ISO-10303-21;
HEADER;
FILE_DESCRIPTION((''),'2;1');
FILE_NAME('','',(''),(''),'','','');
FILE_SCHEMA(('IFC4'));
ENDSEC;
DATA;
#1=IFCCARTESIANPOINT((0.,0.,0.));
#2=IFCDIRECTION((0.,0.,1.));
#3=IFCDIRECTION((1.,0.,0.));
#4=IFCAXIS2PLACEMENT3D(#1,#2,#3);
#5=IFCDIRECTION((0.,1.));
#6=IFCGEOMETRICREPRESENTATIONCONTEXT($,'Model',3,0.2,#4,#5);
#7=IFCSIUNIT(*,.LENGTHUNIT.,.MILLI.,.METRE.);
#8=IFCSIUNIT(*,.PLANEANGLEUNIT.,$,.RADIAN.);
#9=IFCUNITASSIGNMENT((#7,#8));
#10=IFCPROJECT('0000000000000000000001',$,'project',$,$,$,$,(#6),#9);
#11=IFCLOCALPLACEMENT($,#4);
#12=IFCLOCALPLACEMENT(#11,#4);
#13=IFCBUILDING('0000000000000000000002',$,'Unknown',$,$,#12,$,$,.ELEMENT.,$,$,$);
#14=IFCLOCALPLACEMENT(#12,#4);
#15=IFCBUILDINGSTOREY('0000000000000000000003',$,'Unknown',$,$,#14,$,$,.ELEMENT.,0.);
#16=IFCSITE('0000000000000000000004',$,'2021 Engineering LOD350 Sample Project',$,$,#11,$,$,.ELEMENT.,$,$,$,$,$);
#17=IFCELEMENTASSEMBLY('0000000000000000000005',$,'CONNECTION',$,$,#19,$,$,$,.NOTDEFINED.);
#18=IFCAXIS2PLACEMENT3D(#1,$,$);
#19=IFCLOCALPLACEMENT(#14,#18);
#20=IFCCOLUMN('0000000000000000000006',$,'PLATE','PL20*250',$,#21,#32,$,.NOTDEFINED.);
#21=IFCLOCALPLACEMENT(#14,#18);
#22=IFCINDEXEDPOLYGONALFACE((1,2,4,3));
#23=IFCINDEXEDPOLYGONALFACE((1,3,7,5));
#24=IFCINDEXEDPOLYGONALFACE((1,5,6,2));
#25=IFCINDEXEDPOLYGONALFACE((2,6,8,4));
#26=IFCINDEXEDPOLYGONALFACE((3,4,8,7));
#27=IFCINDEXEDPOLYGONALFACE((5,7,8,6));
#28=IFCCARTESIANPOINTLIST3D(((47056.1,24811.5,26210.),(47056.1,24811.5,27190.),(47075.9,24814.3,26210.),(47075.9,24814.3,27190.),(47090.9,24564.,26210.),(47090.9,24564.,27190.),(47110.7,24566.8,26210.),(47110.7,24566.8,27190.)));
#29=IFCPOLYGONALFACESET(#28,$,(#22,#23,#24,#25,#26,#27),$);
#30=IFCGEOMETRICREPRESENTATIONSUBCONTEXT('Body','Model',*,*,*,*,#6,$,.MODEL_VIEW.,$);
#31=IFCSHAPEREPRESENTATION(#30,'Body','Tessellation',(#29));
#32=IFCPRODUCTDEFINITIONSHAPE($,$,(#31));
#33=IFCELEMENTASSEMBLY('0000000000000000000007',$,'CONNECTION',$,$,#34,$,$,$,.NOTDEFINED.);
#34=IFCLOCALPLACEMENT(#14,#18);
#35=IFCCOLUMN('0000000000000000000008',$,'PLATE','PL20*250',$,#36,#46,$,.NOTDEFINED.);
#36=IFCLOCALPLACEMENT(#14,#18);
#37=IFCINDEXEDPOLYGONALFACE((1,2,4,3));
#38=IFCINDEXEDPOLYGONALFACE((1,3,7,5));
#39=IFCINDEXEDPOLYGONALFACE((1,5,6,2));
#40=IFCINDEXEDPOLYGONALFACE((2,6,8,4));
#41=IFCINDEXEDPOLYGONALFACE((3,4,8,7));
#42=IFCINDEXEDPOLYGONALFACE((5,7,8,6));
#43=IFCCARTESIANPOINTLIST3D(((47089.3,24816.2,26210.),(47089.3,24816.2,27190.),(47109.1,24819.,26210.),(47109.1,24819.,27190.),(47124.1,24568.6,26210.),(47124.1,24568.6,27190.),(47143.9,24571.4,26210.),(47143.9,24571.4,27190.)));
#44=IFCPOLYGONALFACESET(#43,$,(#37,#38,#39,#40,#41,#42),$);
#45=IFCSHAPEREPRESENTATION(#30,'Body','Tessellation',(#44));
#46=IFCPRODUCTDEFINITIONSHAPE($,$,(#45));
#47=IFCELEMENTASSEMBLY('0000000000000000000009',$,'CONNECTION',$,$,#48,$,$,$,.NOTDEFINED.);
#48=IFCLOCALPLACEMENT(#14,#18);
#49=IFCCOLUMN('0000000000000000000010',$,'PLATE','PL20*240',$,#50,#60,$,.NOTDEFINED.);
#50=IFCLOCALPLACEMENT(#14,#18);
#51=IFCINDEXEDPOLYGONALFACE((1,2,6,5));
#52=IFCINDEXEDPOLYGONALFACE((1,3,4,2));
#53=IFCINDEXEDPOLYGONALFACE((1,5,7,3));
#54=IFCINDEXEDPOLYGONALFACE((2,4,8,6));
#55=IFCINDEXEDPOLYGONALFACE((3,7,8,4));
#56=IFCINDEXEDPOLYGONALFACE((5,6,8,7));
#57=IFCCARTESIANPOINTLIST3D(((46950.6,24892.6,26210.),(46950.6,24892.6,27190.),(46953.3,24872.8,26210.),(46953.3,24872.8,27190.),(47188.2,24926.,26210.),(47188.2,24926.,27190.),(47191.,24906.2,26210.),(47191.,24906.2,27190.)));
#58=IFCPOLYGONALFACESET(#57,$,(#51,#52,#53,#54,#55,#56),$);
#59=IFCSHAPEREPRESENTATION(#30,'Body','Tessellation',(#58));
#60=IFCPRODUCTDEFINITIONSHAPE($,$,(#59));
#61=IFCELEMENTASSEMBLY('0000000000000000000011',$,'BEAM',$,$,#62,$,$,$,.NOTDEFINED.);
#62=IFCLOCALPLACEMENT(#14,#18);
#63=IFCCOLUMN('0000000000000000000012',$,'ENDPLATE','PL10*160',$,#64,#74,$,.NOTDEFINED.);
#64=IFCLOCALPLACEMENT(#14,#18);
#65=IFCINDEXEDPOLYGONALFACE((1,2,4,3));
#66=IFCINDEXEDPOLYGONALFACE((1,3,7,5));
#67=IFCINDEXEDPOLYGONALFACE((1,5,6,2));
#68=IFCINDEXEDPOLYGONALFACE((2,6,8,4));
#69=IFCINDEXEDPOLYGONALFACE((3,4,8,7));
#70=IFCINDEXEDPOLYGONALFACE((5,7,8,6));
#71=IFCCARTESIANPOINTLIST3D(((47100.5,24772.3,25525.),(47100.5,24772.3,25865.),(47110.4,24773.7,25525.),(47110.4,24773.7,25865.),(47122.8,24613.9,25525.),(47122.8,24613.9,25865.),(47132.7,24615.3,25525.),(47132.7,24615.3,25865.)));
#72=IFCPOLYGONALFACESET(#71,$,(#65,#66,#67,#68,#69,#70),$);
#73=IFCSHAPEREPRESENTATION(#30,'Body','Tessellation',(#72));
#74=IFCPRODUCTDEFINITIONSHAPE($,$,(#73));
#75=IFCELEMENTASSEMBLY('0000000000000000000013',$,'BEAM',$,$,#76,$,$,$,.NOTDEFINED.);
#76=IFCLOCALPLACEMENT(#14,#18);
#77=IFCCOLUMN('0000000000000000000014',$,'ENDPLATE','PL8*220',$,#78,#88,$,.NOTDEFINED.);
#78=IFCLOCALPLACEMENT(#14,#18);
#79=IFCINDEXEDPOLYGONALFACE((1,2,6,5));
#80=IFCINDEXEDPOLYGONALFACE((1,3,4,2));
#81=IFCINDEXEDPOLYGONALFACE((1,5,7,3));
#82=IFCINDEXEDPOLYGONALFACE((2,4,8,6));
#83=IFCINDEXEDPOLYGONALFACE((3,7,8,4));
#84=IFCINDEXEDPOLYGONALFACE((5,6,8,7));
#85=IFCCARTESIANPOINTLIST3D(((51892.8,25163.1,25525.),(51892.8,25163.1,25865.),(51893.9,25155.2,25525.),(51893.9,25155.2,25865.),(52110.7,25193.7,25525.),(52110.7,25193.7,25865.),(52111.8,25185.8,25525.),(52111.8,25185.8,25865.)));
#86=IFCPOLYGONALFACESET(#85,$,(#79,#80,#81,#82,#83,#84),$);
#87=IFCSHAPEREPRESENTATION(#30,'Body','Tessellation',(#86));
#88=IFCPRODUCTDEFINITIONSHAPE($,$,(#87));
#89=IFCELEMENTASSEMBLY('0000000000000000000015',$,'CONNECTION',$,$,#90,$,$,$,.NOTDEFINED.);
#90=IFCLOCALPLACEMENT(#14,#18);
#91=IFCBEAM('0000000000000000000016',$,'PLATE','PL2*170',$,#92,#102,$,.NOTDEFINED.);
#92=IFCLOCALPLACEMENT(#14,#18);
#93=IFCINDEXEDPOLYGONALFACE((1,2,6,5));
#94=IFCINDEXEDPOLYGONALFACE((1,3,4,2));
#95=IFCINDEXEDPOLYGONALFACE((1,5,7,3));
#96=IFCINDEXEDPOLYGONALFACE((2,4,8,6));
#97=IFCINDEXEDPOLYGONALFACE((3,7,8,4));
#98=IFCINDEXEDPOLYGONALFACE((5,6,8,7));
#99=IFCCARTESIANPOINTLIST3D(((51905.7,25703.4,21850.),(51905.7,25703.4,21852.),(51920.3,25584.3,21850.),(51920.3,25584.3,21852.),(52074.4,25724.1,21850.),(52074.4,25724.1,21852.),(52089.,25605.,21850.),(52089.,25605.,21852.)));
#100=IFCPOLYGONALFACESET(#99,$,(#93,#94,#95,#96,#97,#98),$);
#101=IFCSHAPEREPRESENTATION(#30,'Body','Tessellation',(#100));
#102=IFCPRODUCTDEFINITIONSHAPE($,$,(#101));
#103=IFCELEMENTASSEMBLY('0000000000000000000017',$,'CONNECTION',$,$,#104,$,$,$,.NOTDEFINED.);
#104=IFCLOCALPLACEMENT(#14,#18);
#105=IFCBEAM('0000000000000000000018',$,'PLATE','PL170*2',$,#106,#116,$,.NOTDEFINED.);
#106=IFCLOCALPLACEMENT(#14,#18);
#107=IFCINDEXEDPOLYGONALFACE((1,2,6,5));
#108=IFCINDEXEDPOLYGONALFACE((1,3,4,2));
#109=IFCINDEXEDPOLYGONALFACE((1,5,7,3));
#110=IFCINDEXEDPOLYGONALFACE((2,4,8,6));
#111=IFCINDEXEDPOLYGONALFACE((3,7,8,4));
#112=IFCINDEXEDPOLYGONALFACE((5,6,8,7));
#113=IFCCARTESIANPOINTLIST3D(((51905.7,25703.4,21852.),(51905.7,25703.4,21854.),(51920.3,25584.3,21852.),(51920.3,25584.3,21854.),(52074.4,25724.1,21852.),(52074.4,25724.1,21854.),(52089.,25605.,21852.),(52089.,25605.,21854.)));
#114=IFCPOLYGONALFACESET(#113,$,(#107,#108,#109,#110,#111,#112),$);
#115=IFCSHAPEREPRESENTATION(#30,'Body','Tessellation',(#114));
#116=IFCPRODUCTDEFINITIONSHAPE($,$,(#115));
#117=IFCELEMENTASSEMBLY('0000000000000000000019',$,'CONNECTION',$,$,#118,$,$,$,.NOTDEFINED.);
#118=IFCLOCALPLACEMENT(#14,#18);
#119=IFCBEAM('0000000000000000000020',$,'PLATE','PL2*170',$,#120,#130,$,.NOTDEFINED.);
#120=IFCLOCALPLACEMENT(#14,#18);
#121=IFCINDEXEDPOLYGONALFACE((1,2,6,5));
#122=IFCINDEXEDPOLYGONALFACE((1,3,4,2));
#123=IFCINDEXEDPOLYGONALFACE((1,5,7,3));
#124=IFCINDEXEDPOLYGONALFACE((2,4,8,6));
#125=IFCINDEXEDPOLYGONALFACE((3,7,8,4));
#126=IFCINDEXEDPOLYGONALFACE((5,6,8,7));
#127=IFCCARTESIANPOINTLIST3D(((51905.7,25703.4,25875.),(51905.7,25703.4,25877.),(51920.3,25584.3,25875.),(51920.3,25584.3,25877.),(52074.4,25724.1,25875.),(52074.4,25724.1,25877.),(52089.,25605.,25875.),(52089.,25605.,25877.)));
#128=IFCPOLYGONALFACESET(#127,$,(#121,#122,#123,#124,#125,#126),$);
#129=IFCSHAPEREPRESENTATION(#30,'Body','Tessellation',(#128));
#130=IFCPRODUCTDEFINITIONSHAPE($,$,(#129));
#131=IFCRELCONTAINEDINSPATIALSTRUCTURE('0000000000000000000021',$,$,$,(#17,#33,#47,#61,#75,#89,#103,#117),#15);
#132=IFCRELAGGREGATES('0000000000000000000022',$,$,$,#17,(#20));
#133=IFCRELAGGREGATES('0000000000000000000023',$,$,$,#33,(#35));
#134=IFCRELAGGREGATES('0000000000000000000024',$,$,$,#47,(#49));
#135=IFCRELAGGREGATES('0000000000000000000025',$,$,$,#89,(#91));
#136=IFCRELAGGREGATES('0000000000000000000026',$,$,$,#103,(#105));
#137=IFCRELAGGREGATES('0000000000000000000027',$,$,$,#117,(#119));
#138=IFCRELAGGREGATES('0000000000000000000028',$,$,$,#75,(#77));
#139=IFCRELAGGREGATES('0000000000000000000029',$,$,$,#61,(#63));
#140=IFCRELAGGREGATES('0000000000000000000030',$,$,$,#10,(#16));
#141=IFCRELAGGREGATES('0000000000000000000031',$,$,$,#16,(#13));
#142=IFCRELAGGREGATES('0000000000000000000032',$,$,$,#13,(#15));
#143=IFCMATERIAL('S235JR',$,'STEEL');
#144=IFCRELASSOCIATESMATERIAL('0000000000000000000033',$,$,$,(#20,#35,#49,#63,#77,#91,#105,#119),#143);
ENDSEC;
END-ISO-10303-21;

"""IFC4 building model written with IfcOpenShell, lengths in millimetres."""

from ifc_helpers import new_model, si_unit, direction, frame, origin_with_axes, place, context, subcontext, project, spatial, line, indexed_curve, outline, extrude, material, element, aggregate, save


model = new_model("IFC4")

# Units and contexts
model_context = context("Model", 3, precision=0.2, world=origin_with_axes(), true_north=direction((0.0, 1.0)))
body_context = subcontext(model_context, "Body", "Model", "MODEL_VIEW")
ifc_project = project(units=[si_unit("LENGTHUNIT", "METRE", prefix="MILLI"), si_unit("PLANEANGLEUNIT", "RADIAN")], contexts=[model_context])

# Site, building, storey
site_placement = place(None, origin_with_axes())
site = spatial("IfcSite", under=ifc_project, at=site_placement, Name="2021 Engineering LOD350 Sample Project", CompositionType="ELEMENT")
building_placement = place(site_placement, origin_with_axes())
building = spatial("IfcBuilding", under=site, at=building_placement, Name="Unknown", CompositionType="ELEMENT")
storey_placement = place(building_placement, origin_with_axes())
storey = spatial("IfcBuildingStorey", under=building, at=storey_placement, Name="Unknown", CompositionType="ELEMENT", Elevation=0.0)

# Element assemblies, columns
ifc_material_1 = material(Name="S235JR", Category="STEEL")
assembly_1_placement = place(storey_placement, frame((47083.4, 24689.2, 26210.0), z_axis=(-0.990268, -0.139173, 0.0), x_axis=(0.0, 0.0, 1.0)))
assembly_1 = element("IfcElementAssembly", 1, at=assembly_1_placement, inside=storey, Name="CONNECTION", PredefinedType="NOTDEFINED")
column_1_placement = place(assembly_1_placement, origin_with_axes())
column_1 = element("IfcColumn", 2, at=column_1_placement, material=ifc_material_1, Name="PLATE", Description="PL20*250", PredefinedType="NOTDEFINED", context=body_context, shape_type="SolidModel", body=[
    extrude(outline(indexed_curve([(-10.0, -125.0), (10.0, -125.0), (10.0, 125.0), (-10.0, 125.0)], segments=[line(1, 2, 3, 4, 1)])), frame((0.0, 0.0, 0.0), z_axis=(-1.0, 0.0, 0.0), x_axis=(0.0, 0.0, 1.0)), (0.0, 0.0, -1.0), 980.0),
])
aggregate(assembly_1, [column_1])
assembly_2_placement = place(storey_placement, frame((47116.6, 24693.8, 26210.0), z_axis=(-0.990268, -0.139173, 0.0), x_axis=(0.0, 0.0, 1.0)))
assembly_2 = element("IfcElementAssembly", 3, at=assembly_2_placement, inside=storey, Name="CONNECTION", PredefinedType="NOTDEFINED")
column_2_placement = place(assembly_2_placement, origin_with_axes())
column_2 = element("IfcColumn", 4, at=column_2_placement, material=ifc_material_1, Name="PLATE", Description="PL20*250", PredefinedType="NOTDEFINED", context=body_context, shape_type="SolidModel", body=[
    extrude(outline(indexed_curve([(-10.0, -125.0), (10.0, -125.0), (10.0, 125.0), (-10.0, 125.0)], segments=[line(1, 2, 3, 4, 1)])), frame((0.0, 0.0, 0.0), z_axis=(-1.0, 0.0, 0.0), x_axis=(0.0, 0.0, 1.0)), (0.0, 0.0, -1.0), 980.0),
])
aggregate(assembly_2, [column_2])
assembly_3_placement = place(storey_placement, frame((47070.8, 24899.4, 26210.0), z_axis=(-0.139173, 0.990268, 0.0), x_axis=(0.0, 0.0, 1.0)))
assembly_3 = element("IfcElementAssembly", 5, at=assembly_3_placement, inside=storey, Name="CONNECTION", PredefinedType="NOTDEFINED")
column_3_placement = place(assembly_3_placement, origin_with_axes())
column_3 = element("IfcColumn", 6, at=column_3_placement, material=ifc_material_1, Name="PLATE", Description="PL20*240", PredefinedType="NOTDEFINED", context=body_context, shape_type="SolidModel", body=[
    extrude(outline(indexed_curve([(-10.0, -120.0), (10.0, -120.0), (10.0, 120.0), (-10.0, 120.0)], segments=[line(1, 2, 3, 4, 1)])), frame((0.0, 0.0, 0.0), z_axis=(-1.0, 0.0, 0.0), x_axis=(0.0, 0.0, 1.0)), (0.0, 0.0, -1.0), 980.0),
])
aggregate(assembly_3, [column_3])
assembly_4_placement = place(storey_placement, frame((47100.0, 24691.5, 25695.0), z_axis=(0.139173, -0.990268, 0.0), x_axis=(0.990268, 0.139173, 0.0)))
assembly_4 = element("IfcElementAssembly", 7, at=assembly_4_placement, inside=storey, Name="BEAM", PredefinedType="NOTDEFINED")
column_4_placement = place(assembly_4_placement, frame((16.8, -170.0, 0.0), z_axis=(1.0, 0.0, 0.0), x_axis=(0.0, 1.0, 0.0)))
column_4 = element("IfcColumn", 8, at=column_4_placement, material=ifc_material_1, Name="ENDPLATE", Description="PL10*160", PredefinedType="NOTDEFINED", context=body_context, shape_type="SolidModel", body=[
    extrude(outline(indexed_curve([(-5.0, -80.0), (5.0, -80.0), (5.0, 80.0), (-5.0, 80.0)], segments=[line(1, 2, 3, 4, 1)])), frame((0.0, 0.0, 0.0), z_axis=(-1.0, 0.0, 0.0), x_axis=(0.0, 0.0, 1.0)), (0.0, 0.0, -1.0), 340.0),
])
assembly_5_placement = place(storey_placement, frame((51975.0, 25483.7, 25695.0), z_axis=(-1.0, 0.0, 0.0), x_axis=(0.0, -1.0, 0.0)))
assembly_5 = element("IfcElementAssembly", 9, at=assembly_5_placement, inside=storey, Name="BEAM", PredefinedType="NOTDEFINED")
column_5_placement = place(assembly_5_placement, frame((309.2, -170.0, -27.3), z_axis=(0.990268, 0.0, -0.139173), x_axis=(0.0, 1.0, 0.0)))
column_5 = element("IfcColumn", 10, at=column_5_placement, material=ifc_material_1, Name="ENDPLATE", Description="PL8*220", PredefinedType="NOTDEFINED", context=body_context, shape_type="SolidModel", body=[
    extrude(outline(indexed_curve([(-4.0, -110.0), (4.0, -110.0), (4.0, 110.0), (-4.0, 110.0)], segments=[line(1, 2, 3, 4, 1)])), frame((0.0, 0.0, 0.0), z_axis=(-1.0, 0.0, 0.0), x_axis=(0.0, 0.0, 1.0)), (0.0, 0.0, -1.0), 340.0),
])

# Element assemblies, beams
assembly_6_placement = place(storey_placement, frame((52004.7, 25594.6, 21851.0), z_axis=(0.0, 0.0, -1.0), x_axis=(-0.121869, 0.992546, 0.0)))
assembly_6 = element("IfcElementAssembly", 11, at=assembly_6_placement, inside=storey, Name="CONNECTION", PredefinedType="NOTDEFINED")
beam_1_placement = place(assembly_6_placement, origin_with_axes())
beam_1 = element("IfcBeam", 12, at=beam_1_placement, material=ifc_material_1, Name="PLATE", Description="PL2*170", PredefinedType="NOTDEFINED", context=body_context, shape_type="SolidModel", body=[
    extrude(outline(indexed_curve([(-1.0, -85.0), (1.0, -85.0), (1.0, 85.0), (-1.0, 85.0)], segments=[line(1, 2, 3, 4, 1)])), frame((0.0, 0.0, 0.0), z_axis=(-1.0, 0.0, 0.0), x_axis=(0.0, 0.0, 1.0)), (0.0, 0.0, -1.0), 120.0),
])
aggregate(assembly_6, [beam_1])
assembly_7_placement = place(storey_placement, frame((52004.7, 25594.6, 21853.0), z_axis=(0.0, 0.0, -1.0), x_axis=(-0.121869, 0.992546, 0.0)))
assembly_7 = element("IfcElementAssembly", 13, at=assembly_7_placement, inside=storey, Name="CONNECTION", PredefinedType="NOTDEFINED")
beam_2_placement = place(assembly_7_placement, origin_with_axes())
beam_2 = element("IfcBeam", 14, at=beam_2_placement, material=ifc_material_1, Name="PLATE", Description="PL170*2", PredefinedType="NOTDEFINED", context=body_context, shape_type="SolidModel", body=[
    extrude(outline(indexed_curve([(-1.0, -85.0), (1.0, -85.0), (1.0, 85.0), (-1.0, 85.0)], segments=[line(1, 2, 3, 4, 1)])), frame((0.0, 0.0, 0.0), z_axis=(-1.0, 0.0, 0.0), x_axis=(0.0, 0.0, 1.0)), (0.0, 0.0, -1.0), 120.0),
])
aggregate(assembly_7, [beam_2])
assembly_8_placement = place(storey_placement, frame((52004.7, 25594.6, 25876.0), z_axis=(0.0, 0.0, -1.0), x_axis=(-0.121869, 0.992546, 0.0)))
assembly_8 = element("IfcElementAssembly", 15, at=assembly_8_placement, inside=storey, Name="CONNECTION", PredefinedType="NOTDEFINED")
beam_3_placement = place(assembly_8_placement, origin_with_axes())
beam_3 = element("IfcBeam", 16, at=beam_3_placement, material=ifc_material_1, Name="PLATE", Description="PL2*170", PredefinedType="NOTDEFINED", context=body_context, shape_type="SolidModel", body=[
    extrude(outline(indexed_curve([(-1.0, -85.0), (1.0, -85.0), (1.0, 85.0), (-1.0, 85.0)], segments=[line(1, 2, 3, 4, 1)])), frame((0.0, 0.0, 0.0), z_axis=(-1.0, 0.0, 0.0), x_axis=(0.0, 0.0, 1.0)), (0.0, 0.0, -1.0), 120.0),
])
aggregate(assembly_8, [beam_3])

aggregate(assembly_5, [column_5])
aggregate(assembly_4, [column_4])

save(model, "model.ifc")
